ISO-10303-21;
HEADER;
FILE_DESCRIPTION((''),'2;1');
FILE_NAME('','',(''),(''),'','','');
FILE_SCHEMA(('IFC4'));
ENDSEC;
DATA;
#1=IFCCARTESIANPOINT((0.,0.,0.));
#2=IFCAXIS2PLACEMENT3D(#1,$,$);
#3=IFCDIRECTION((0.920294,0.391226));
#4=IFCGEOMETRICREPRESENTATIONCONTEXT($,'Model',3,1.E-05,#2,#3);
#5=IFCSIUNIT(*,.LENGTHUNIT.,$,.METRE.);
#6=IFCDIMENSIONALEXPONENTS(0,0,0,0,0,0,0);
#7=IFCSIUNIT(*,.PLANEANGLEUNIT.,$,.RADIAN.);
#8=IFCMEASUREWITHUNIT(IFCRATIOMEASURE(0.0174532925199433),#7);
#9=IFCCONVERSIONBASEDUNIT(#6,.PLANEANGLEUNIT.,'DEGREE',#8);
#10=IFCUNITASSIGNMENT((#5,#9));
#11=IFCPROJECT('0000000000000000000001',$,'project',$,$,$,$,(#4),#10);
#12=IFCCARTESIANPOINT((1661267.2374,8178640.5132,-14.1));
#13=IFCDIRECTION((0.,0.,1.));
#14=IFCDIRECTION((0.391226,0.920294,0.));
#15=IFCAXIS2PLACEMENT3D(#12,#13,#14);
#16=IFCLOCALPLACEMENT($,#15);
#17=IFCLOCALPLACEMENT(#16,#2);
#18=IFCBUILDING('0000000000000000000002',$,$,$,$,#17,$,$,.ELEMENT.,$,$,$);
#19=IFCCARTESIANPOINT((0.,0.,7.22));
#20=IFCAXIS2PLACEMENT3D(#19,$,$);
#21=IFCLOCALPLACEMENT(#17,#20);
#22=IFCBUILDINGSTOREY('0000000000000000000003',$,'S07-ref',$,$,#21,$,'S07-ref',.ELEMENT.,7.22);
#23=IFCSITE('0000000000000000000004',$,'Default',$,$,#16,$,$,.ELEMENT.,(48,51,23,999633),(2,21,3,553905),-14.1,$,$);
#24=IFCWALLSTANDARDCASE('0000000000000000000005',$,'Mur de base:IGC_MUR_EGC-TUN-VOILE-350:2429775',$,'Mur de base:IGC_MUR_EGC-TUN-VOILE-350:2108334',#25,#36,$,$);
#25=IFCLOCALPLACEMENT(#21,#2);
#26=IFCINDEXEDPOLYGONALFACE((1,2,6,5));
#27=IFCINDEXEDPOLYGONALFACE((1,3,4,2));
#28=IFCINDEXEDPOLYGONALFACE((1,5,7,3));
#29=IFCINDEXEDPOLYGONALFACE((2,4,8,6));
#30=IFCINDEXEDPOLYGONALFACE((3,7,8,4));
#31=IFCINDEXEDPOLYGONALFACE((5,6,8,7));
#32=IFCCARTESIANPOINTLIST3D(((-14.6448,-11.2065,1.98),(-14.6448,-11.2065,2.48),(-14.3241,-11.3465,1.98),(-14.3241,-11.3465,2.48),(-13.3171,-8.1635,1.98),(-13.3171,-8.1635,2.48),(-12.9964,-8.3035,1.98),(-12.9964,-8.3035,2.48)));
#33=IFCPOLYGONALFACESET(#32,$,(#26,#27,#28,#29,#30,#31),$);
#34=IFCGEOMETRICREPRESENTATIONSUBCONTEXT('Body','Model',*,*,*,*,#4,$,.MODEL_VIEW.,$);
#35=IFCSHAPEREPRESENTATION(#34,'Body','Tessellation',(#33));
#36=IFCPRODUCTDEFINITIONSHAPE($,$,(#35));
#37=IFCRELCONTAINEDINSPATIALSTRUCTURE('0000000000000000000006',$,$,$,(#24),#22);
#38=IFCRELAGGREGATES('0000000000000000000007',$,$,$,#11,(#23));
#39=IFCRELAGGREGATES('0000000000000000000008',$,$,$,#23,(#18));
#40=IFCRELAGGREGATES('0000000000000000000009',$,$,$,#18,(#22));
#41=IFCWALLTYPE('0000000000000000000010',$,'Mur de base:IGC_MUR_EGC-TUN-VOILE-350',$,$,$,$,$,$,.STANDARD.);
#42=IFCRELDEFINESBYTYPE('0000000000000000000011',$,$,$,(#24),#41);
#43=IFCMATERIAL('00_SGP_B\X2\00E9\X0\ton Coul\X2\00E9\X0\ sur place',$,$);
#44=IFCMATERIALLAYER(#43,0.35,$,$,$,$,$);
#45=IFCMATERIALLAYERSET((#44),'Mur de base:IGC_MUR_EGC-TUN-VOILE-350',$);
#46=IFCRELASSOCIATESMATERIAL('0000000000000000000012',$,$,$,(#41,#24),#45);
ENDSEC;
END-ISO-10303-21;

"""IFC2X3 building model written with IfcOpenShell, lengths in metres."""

from ifc_helpers import new_model, entity, si_unit, converted_unit, direction, frame, frame_2d, origin, place, context, subcontext, project, spatial, rectangle, extrude, material, layer, layer_set, layer_usage, type_object, element, save


model = new_model("IFC2X3")

# Units and contexts
model_context = context("Model", 3, precision=1e-05, world=origin(), true_north=direction((0.920294, 0.391226)))
body_context = subcontext(model_context, "Body", "Model", "MODEL_VIEW")
ifc_project = project(units=[si_unit("LENGTHUNIT", "METRE"), converted_unit("PLANEANGLEUNIT", "DEGREE", entity("IfcRatioMeasure", 0.0174532925199433), si_unit("PLANEANGLEUNIT", "RADIAN"), dimensions=[0, 0, 0, 0, 0, 0, 0])], contexts=[model_context])

# Site, building, storey
site_placement = place(None, frame((1661267.2374, 8178640.5132, -14.1), z_axis=(0.0, 0.0, 1.0), x_axis=(0.391226, 0.920294, 0.0)))
site = spatial("IfcSite", under=ifc_project, at=site_placement, Name="Default", CompositionType="ELEMENT", RefLatitude=(48, 51, 23, 999633), RefLongitude=(2, 21, 3, 553905), RefElevation=-14.1)
building_placement = place(site_placement, origin())
building = spatial("IfcBuilding", under=site, at=building_placement, CompositionType="ELEMENT")
storey_placement = place(building_placement, frame((0.0, 0.0, 7.22)))
storey = spatial("IfcBuildingStorey", under=building, at=storey_placement, Name="S07-ref", LongName="S07-ref", CompositionType="ELEMENT", Elevation=7.22)

# Shared definitions
ifc_material = material(Name="00_SGP_Béton Coulé sur place")

# Wall
ifc_layer_1 = layer(ifc_material, 0.35)
ifc_layer_set_1 = layer_set([ifc_layer_1], Name="Mur de base:IGC_MUR_EGC-TUN-VOILE-350")
ifc_layer_usage_1 = layer_usage(ifc_layer_set_1, "AXIS2", "POSITIVE", -0.175)
wall_type_1 = type_object("IfcWallType", Name="Mur de base:IGC_MUR_EGC-TUN-VOILE-350", PredefinedType="STANDARD", material=ifc_layer_set_1)
wall_1_placement = place(storey_placement, frame((-13.1568, -8.2335, 1.98), z_axis=(0.0, 0.0, 1.0), x_axis=(-0.39991, -0.916554, 0.0)))
element("IfcWallStandardCase", 1, at=wall_1_placement, inside=storey, type_object=wall_type_1, material=ifc_layer_usage_1, Name="Mur de base:IGC_MUR_EGC-TUN-VOILE-350:2429775", ObjectType="Mur de base:IGC_MUR_EGC-TUN-VOILE-350:2108334", context=body_context, shape_type="SweptSolid", body=[
    extrude(rectangle(XDim=3.32, YDim=0.35, at=frame_2d((1.66, 0.0), x_axis=(-1.0, 0.0))), origin(), (0.0, 0.0, 1.0), 0.5),
])

save(model, "model.ifc")
